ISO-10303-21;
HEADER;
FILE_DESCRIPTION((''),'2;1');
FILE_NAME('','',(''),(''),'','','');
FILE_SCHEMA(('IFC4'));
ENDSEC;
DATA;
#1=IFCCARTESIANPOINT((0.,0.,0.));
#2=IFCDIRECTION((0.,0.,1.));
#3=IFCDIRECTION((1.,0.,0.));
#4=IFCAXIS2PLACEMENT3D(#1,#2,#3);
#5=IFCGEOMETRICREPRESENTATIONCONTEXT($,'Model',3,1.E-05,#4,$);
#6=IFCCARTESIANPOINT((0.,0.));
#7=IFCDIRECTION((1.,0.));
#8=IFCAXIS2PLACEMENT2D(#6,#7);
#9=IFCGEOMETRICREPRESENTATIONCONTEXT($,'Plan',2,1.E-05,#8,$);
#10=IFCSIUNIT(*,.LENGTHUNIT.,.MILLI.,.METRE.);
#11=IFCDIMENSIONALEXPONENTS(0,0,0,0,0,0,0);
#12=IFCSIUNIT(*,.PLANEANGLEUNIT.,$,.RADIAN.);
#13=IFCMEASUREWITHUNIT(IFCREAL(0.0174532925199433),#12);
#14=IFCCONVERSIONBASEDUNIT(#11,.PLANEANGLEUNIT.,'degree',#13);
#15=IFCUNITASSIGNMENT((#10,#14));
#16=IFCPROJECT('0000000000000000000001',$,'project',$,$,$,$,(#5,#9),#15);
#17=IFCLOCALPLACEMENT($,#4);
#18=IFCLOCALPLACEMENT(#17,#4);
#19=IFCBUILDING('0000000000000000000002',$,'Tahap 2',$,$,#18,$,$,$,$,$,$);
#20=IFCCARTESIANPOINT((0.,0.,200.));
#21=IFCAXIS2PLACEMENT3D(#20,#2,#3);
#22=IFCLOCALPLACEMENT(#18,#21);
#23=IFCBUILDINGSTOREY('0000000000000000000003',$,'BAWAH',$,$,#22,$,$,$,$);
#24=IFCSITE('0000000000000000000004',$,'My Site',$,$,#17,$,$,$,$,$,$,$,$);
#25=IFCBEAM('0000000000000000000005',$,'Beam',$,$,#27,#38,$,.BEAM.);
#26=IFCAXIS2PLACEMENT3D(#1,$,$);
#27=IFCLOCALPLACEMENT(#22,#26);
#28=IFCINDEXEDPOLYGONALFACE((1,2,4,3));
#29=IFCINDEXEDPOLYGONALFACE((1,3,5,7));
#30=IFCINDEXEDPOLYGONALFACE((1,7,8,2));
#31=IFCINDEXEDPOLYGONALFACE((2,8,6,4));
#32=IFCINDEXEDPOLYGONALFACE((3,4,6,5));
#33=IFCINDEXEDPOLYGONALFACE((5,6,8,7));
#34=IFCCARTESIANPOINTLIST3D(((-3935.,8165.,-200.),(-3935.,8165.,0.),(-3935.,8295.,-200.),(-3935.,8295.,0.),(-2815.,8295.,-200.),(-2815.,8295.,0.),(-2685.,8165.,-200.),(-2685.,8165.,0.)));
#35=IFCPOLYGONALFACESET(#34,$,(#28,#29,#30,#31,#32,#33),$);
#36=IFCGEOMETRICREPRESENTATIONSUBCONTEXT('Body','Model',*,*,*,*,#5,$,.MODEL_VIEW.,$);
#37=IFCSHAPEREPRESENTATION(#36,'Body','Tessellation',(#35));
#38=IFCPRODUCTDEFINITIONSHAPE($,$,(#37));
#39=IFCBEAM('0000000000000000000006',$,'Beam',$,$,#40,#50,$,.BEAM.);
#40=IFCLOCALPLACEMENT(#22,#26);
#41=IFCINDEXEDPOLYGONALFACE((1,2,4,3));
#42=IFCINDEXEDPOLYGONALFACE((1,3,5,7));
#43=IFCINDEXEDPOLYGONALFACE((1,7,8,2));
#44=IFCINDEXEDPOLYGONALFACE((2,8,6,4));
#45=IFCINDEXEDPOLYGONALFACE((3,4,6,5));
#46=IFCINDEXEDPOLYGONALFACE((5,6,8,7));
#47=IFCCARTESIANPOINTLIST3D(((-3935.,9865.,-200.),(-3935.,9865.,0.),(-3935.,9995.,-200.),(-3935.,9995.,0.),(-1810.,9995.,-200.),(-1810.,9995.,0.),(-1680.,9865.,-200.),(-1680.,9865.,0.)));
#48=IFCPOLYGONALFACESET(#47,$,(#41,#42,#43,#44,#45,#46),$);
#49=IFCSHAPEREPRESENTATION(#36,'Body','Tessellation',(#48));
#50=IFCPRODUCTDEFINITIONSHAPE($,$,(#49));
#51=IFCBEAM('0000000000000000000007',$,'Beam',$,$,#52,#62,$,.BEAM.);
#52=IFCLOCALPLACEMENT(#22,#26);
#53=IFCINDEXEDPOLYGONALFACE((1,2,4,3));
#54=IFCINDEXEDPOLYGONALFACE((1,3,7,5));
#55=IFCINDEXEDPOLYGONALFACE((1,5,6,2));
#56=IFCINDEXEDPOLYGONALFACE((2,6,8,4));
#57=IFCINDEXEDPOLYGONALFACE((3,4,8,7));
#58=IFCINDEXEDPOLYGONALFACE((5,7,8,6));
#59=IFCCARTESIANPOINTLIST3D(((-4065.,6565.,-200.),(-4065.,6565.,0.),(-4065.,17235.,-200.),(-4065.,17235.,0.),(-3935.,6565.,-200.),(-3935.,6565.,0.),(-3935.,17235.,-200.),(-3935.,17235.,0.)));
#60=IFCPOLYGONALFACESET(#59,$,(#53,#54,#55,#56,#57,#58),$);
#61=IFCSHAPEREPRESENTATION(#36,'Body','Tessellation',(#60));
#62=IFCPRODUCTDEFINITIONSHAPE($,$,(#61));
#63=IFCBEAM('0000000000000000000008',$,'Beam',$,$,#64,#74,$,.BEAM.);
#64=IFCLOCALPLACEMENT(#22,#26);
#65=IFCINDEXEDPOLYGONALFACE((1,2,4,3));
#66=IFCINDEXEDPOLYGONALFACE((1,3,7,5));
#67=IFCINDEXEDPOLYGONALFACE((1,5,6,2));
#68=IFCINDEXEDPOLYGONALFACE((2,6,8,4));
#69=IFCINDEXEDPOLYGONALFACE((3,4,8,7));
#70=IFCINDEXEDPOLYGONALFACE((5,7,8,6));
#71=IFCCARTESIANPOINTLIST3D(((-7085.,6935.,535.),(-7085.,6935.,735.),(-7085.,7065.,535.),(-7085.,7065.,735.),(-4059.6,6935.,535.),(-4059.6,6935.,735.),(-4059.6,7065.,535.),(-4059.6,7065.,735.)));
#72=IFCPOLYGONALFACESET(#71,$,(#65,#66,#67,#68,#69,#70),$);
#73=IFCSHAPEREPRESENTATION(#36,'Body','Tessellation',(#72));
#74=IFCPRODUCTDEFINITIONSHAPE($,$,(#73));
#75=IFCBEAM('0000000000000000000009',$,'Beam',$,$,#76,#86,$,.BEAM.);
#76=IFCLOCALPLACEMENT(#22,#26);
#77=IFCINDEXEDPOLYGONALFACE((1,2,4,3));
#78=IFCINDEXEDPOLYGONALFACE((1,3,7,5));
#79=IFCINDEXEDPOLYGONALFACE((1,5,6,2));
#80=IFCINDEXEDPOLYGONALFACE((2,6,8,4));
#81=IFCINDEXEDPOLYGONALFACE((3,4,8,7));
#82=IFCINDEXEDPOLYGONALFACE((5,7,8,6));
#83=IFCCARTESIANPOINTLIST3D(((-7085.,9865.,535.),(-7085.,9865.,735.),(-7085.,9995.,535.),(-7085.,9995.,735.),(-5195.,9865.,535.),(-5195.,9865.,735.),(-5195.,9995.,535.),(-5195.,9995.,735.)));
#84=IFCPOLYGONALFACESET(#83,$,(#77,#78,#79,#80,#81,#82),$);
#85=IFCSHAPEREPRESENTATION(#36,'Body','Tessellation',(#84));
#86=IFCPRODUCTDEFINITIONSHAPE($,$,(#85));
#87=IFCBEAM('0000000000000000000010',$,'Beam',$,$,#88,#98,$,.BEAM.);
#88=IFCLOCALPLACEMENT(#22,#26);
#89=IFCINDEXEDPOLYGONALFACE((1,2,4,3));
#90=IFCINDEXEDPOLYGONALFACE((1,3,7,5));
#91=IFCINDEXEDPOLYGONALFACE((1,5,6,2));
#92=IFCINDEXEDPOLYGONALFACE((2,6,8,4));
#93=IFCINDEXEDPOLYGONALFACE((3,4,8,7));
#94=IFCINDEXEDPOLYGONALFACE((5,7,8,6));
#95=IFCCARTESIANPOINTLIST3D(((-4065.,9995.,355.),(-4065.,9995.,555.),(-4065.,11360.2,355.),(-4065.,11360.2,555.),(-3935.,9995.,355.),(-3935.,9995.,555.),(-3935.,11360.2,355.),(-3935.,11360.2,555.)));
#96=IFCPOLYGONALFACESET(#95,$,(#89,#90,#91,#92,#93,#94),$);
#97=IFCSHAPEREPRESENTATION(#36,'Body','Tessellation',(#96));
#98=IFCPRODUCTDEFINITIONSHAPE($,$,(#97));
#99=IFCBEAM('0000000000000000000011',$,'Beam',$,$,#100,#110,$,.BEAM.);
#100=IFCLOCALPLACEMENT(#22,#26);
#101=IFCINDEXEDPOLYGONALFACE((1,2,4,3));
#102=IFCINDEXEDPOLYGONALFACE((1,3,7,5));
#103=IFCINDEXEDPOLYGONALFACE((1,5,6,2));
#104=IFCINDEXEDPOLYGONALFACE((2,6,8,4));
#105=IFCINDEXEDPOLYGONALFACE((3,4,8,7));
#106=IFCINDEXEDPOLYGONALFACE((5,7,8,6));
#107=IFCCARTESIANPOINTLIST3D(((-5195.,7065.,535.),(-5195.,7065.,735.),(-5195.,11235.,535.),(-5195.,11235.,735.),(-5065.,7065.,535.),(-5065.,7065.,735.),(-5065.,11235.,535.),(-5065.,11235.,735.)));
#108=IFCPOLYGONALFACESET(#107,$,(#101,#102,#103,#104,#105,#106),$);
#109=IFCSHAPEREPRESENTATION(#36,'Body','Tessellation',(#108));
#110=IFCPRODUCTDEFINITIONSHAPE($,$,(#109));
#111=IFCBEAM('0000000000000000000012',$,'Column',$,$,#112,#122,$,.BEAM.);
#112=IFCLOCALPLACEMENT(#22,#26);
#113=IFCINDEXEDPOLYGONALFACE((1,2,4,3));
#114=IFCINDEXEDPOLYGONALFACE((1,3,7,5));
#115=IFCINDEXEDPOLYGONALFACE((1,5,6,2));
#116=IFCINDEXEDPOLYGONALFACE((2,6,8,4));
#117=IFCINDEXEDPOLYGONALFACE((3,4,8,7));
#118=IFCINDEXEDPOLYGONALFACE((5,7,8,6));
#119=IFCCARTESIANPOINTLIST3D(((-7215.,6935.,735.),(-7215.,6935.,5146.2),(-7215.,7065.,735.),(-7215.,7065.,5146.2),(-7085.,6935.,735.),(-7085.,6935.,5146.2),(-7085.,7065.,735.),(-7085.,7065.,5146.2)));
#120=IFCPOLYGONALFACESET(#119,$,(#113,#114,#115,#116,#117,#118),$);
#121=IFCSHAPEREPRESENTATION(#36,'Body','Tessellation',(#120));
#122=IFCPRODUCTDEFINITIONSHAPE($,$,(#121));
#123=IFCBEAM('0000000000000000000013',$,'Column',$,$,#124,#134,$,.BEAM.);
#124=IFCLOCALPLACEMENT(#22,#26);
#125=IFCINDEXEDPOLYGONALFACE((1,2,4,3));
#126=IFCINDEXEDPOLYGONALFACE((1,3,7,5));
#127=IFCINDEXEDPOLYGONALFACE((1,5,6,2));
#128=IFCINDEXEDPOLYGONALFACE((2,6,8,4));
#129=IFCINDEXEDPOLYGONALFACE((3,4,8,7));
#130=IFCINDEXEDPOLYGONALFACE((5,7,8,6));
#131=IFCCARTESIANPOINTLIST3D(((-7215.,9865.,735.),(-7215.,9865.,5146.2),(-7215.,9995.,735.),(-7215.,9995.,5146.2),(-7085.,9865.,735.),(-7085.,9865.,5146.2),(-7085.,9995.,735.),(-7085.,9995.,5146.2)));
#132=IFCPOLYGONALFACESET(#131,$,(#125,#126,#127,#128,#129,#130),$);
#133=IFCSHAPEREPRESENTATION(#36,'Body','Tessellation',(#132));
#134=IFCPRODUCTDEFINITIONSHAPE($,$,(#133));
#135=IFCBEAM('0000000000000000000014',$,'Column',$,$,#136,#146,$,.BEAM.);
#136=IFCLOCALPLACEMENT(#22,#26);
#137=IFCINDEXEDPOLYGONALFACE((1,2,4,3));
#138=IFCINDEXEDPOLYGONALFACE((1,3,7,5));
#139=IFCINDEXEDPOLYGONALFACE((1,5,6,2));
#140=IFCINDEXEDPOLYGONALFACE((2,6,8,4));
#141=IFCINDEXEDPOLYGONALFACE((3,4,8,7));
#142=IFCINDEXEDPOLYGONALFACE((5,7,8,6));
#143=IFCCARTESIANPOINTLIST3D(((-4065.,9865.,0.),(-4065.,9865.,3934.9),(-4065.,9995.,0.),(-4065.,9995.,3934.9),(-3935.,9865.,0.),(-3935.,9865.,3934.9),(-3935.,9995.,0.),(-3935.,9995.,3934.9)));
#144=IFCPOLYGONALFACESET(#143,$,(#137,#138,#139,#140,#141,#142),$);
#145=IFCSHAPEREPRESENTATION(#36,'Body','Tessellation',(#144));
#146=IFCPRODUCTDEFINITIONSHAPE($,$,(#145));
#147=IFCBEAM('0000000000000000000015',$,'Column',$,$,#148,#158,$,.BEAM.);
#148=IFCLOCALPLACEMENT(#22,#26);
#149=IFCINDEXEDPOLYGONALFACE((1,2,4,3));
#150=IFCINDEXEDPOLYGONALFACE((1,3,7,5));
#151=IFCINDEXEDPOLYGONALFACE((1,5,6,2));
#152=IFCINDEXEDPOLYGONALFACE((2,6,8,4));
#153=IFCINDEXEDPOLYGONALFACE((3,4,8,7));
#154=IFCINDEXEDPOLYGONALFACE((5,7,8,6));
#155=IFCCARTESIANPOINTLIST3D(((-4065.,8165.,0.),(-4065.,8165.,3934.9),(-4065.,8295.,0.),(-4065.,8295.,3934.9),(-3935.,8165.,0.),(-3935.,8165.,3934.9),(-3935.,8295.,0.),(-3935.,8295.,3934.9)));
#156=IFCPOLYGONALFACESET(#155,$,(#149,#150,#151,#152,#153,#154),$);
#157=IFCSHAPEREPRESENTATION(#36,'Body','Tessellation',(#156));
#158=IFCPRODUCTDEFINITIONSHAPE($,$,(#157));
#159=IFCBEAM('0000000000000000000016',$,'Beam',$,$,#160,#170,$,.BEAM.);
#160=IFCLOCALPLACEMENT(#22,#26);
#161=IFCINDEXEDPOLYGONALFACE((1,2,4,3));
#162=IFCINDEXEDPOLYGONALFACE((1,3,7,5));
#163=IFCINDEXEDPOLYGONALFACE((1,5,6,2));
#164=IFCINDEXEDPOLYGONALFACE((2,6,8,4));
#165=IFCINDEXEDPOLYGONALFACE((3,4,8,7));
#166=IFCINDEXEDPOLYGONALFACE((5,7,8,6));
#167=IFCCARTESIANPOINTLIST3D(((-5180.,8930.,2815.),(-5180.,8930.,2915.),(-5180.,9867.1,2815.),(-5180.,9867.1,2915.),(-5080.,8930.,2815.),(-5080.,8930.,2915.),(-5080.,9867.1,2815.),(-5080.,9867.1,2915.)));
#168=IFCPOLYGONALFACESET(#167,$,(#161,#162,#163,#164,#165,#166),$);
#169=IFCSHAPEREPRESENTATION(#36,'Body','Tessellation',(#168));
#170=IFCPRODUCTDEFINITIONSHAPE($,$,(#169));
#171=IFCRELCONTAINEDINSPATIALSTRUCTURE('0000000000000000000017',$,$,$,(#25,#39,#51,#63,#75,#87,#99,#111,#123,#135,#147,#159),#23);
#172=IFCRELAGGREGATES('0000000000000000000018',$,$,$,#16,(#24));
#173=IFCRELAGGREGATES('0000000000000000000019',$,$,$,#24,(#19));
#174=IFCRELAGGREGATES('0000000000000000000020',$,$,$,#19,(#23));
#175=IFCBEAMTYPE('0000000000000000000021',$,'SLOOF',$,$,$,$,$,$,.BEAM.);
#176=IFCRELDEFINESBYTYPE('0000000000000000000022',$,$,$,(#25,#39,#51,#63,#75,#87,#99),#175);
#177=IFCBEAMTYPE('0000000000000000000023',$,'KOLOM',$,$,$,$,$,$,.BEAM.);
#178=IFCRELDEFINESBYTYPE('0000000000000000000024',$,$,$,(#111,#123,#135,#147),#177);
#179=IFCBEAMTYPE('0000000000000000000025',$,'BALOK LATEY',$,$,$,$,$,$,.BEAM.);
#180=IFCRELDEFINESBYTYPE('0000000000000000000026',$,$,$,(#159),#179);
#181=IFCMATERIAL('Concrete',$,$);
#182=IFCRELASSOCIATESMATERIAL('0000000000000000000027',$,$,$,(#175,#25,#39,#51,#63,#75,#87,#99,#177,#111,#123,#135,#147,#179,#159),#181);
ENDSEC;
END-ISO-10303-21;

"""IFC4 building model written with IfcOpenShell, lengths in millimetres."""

from ifc_helpers import new_model, entity, si_unit, converted_unit, frame, origin_with_axes, origin_2d_with_axis, place, context, subcontext, project, spatial, indexed_curve, rectangle, outline, extrude, clip, halfspace, material, material_profile, profile_set, profile_usage, type_object, element, save


model = new_model("IFC4")

# Units and contexts
model_context = context("Model", 3, precision=1e-05, world=origin_with_axes())
plan_context = context("Plan", 2, precision=1e-05, world=origin_2d_with_axis())
body_context_1 = subcontext(model_context, "Body", "Model", "MODEL_VIEW")
ifc_project = project(units=[si_unit("LENGTHUNIT", "METRE", prefix="MILLI"), converted_unit("PLANEANGLEUNIT", "degree", entity("IfcReal", 0.0174532925199433), si_unit("PLANEANGLEUNIT", "RADIAN"), dimensions=[0, 0, 0, 0, 0, 0, 0])], contexts=[model_context, plan_context])

# Site, building, storey
site_placement = place(None, origin_with_axes())
site = spatial("IfcSite", under=ifc_project, at=site_placement, Name="My Site")
building_placement = place(site_placement, origin_with_axes())
building = spatial("IfcBuilding", under=site, at=building_placement, Name="Tahap 2")
storey_placement = place(building_placement, frame((0.0, 0.0, 200.0), z_axis=(0.0, 0.0, 1.0), x_axis=(1.0, 0.0, 0.0)))
storey = spatial("IfcBuildingStorey", under=building, at=storey_placement, Name="BAWAH")

# Beams
ifc_material_1 = material(Name="Concrete")
ifc_material_profile_1 = material_profile(ifc_material_1, outline(indexed_curve([(-65.0, 100.0), (65.0, 100.0), (65.0, -100.0), (-65.0, -100.0), (-65.0, 100.0)])))
ifc_profile_set_1 = profile_set([ifc_material_profile_1])
ifc_profile_usage_1 = profile_usage(ifc_profile_set_1, cardinal=2)
beam_type_1 = type_object("IfcBeamType", Name="SLOOF", PredefinedType="BEAM", material=ifc_profile_set_1)
beam_1_placement = place(storey_placement, frame((-3935.0, 8230.0, -200.0), z_axis=(1.0, 0.0, 0.0), x_axis=(0.0, 1.0, 0.0)))
element("IfcBeam", 1, at=beam_1_placement, inside=storey, type_object=beam_type_1, material=ifc_profile_usage_1, Name="Beam", PredefinedType="BEAM", context=body_context_1, shape_type="Clipping", body=[
    clip(extrude(outline(indexed_curve([(-65.0, 100.0), (65.0, 100.0), (65.0, -100.0), (-65.0, -100.0), (-65.0, 100.0)])), frame((0.0, 100.0, 0.0), z_axis=(0.0, 0.0, 1.0), x_axis=(1.0, 0.0, 0.0)), (0.0, 0.0, 1.0), 1250.0), halfspace(frame((-65.0, 0.0, 1250.0), z_axis=(0.707109, 0.0, 0.707104), x_axis=(0.0, -1.0, 0.0)), False)),
])
ifc_profile_usage_2 = profile_usage(ifc_profile_set_1, cardinal=2)
beam_2_placement = place(storey_placement, frame((-3935.0, 9930.0, -200.0), z_axis=(1.0, 0.000001, 0.0), x_axis=(-0.000001, 1.0, 0.0)))
element("IfcBeam", 2, at=beam_2_placement, inside=storey, type_object=beam_type_1, material=ifc_profile_usage_2, Name="Beam", PredefinedType="BEAM", context=body_context_1, shape_type="Clipping", body=[
    clip(extrude(outline(indexed_curve([(-65.0, 100.0), (65.0, 100.0), (65.0, -100.0), (-65.0, -100.0), (-65.0, 100.0)])), frame((0.0, 100.0, 0.0), z_axis=(0.0, 0.0, 1.0), x_axis=(1.0, 0.0, 0.0)), (0.0, 0.0, 1.0), 2255.0), halfspace(frame((-65.0, 0.0, 2255.0), z_axis=(0.707109, 0.0, 0.707104), x_axis=(0.0, -1.0, 0.0)), False)),
])
ifc_profile_usage_3 = profile_usage(ifc_profile_set_1, cardinal=3)
beam_3_placement = place(storey_placement, frame((-3935.0, 6565.0, -200.0), z_axis=(0.0, 1.0, 0.0), x_axis=(-1.0, 0.0, 0.0)))
element("IfcBeam", 3, at=beam_3_placement, inside=storey, type_object=beam_type_1, material=ifc_profile_usage_3, Name="Beam", PredefinedType="BEAM", context=body_context_1, shape_type="SweptSolid", body=[
    extrude(outline(indexed_curve([(-65.0, 100.0), (65.0, 100.0), (65.0, -100.0), (-65.0, -100.0), (-65.0, 100.0)])), frame((65.0, 100.0, 0.0), z_axis=(0.0, 0.0, 1.0), x_axis=(1.0, 0.0, 0.0)), (0.0, 0.0, 1.0), 10670.0),
])
ifc_profile_usage_4 = profile_usage(ifc_profile_set_1, cardinal=2)
beam_4_placement = place(storey_placement, frame((-7085.0, 7000.0, 535.0), z_axis=(1.0, 0.0, 0.0), x_axis=(0.0, 1.0, 0.0)))
element("IfcBeam", 4, at=beam_4_placement, inside=storey, type_object=beam_type_1, material=ifc_profile_usage_4, Name="Beam", PredefinedType="BEAM", context=body_context_1, shape_type="SweptSolid", body=[
    extrude(outline(indexed_curve([(-65.0, 100.0), (65.0, 100.0), (65.0, -100.0), (-65.0, -100.0), (-65.0, 100.0)])), frame((0.0, 100.0, 0.0), z_axis=(0.0, 0.0, 1.0), x_axis=(1.0, 0.0, 0.0)), (0.0, 0.0, 1.0), 3025.4),
])
ifc_profile_usage_5 = profile_usage(ifc_profile_set_1, cardinal=2)
beam_5_placement = place(storey_placement, frame((-7085.0, 9930.0, 535.0), z_axis=(1.0, 0.0, 0.0), x_axis=(0.0, 1.0, 0.0)))
element("IfcBeam", 5, at=beam_5_placement, inside=storey, type_object=beam_type_1, material=ifc_profile_usage_5, Name="Beam", PredefinedType="BEAM", context=body_context_1, shape_type="SweptSolid", body=[
    extrude(outline(indexed_curve([(-65.0, 100.0), (65.0, 100.0), (65.0, -100.0), (-65.0, -100.0), (-65.0, 100.0)])), frame((0.0, 100.0, 0.0), z_axis=(0.0, 0.0, 1.0), x_axis=(1.0, 0.0, 0.0)), (0.0, 0.0, 1.0), 1890.0),
])
ifc_profile_usage_6 = profile_usage(ifc_profile_set_1, cardinal=3)
beam_6_placement = place(storey_placement, frame((-3935.0, 9995.0, 355.0), z_axis=(0.0, 1.0, 0.0), x_axis=(-1.0, 0.0, 0.0)))
element("IfcBeam", 6, at=beam_6_placement, inside=storey, type_object=beam_type_1, material=ifc_profile_usage_6, Name="Beam", PredefinedType="BEAM", context=body_context_1, shape_type="SweptSolid", body=[
    extrude(outline(indexed_curve([(-65.0, 100.0), (65.0, 100.0), (65.0, -100.0), (-65.0, -100.0), (-65.0, 100.0)])), frame((65.0, 100.0, 0.0), z_axis=(0.0, 0.0, 1.0), x_axis=(1.0, 0.0, 0.0)), (0.0, 0.0, 1.0), 1365.2),
])
ifc_profile_usage_7 = profile_usage(ifc_profile_set_1, cardinal=3)
beam_7_placement = place(storey_placement, frame((-5065.0, 7065.0, 535.0), z_axis=(0.0, 1.0, 0.0), x_axis=(-1.0, 0.0, 0.0)))
element("IfcBeam", 7, at=beam_7_placement, inside=storey, type_object=beam_type_1, material=ifc_profile_usage_7, Name="Beam", PredefinedType="BEAM", context=body_context_1, shape_type="SweptSolid", body=[
    extrude(outline(indexed_curve([(-65.0, 100.0), (65.0, 100.0), (65.0, -100.0), (-65.0, -100.0), (-65.0, 100.0)])), frame((65.0, 100.0, 0.0), z_axis=(0.0, 0.0, 1.0), x_axis=(1.0, 0.0, 0.0)), (0.0, 0.0, 1.0), 4170.0),
])
ifc_material_profile_2 = material_profile(ifc_material_1, rectangle(XDim=130.0, YDim=130.0, kind="CURVE"))
ifc_profile_set_2 = profile_set([ifc_material_profile_2])
ifc_profile_usage_8 = profile_usage(ifc_profile_set_2, cardinal=5)
beam_type_2 = type_object("IfcBeamType", Name="KOLOM", PredefinedType="BEAM", material=ifc_profile_set_2)
beam_8_placement = place(storey_placement, frame((-7150.0, 7000.0, 735.0), z_axis=(0.0, 0.0, 1.0), x_axis=(1.0, 0.0, 0.0)))
element("IfcBeam", 8, at=beam_8_placement, inside=storey, type_object=beam_type_2, material=ifc_profile_usage_8, Name="Column", PredefinedType="BEAM", context=body_context_1, shape_type="SweptSolid", body=[
    extrude(rectangle(XDim=130.0, YDim=130.0, kind="CURVE"), origin_with_axes(), (0.0, 0.0, 1.0), 4411.2),
])
ifc_profile_usage_9 = profile_usage(ifc_profile_set_2, cardinal=5)
beam_9_placement = place(storey_placement, frame((-7150.0, 9930.0, 735.0), z_axis=(0.0, 0.0, 1.0), x_axis=(1.0, 0.0, 0.0)))
element("IfcBeam", 9, at=beam_9_placement, inside=storey, type_object=beam_type_2, material=ifc_profile_usage_9, Name="Column", PredefinedType="BEAM", context=body_context_1, shape_type="SweptSolid", body=[
    extrude(rectangle(XDim=130.0, YDim=130.0, kind="CURVE"), origin_with_axes(), (0.0, 0.0, 1.0), 4411.2),
])
ifc_profile_usage_10 = profile_usage(ifc_profile_set_2, cardinal=5)
beam_10_placement = place(storey_placement, frame((-4000.0, 9930.0, 0.0), z_axis=(0.0, 0.0, 1.0), x_axis=(1.0, 0.0, 0.0)))
element("IfcBeam", 10, at=beam_10_placement, inside=storey, type_object=beam_type_2, material=ifc_profile_usage_10, Name="Column", PredefinedType="BEAM", context=body_context_1, shape_type="SweptSolid", body=[
    extrude(rectangle(XDim=130.0, YDim=130.0, kind="CURVE"), origin_with_axes(), (0.0, 0.0, 1.0), 3934.9),
])
ifc_profile_usage_11 = profile_usage(ifc_profile_set_2, cardinal=5)
beam_11_placement = place(storey_placement, frame((-4000.0, 8230.0, 0.0), z_axis=(0.0, 0.0, 1.0), x_axis=(1.0, 0.0, 0.0)))
element("IfcBeam", 11, at=beam_11_placement, inside=storey, type_object=beam_type_2, material=ifc_profile_usage_11, Name="Column", PredefinedType="BEAM", context=body_context_1, shape_type="SweptSolid", body=[
    extrude(rectangle(XDim=130.0, YDim=130.0, kind="CURVE"), origin_with_axes(), (0.0, 0.0, 1.0), 3934.9),
])

# Beam
ifc_material_profile_3 = material_profile(ifc_material_1, rectangle(XDim=100.0, YDim=100.0))
ifc_profile_set_3 = profile_set([ifc_material_profile_3])
ifc_profile_usage_12 = profile_usage(ifc_profile_set_3, cardinal=2)
beam_type_3 = type_object("IfcBeamType", Name="BALOK LATEY", PredefinedType="BEAM", material=ifc_profile_set_3)
beam_12_placement = place(storey_placement, frame((-5130.0, 8930.0, 2815.0), z_axis=(0.0, 1.0, 0.0), x_axis=(-1.0, 0.0, 0.0)))
element("IfcBeam", 12, at=beam_12_placement, inside=storey, type_object=beam_type_3, material=ifc_profile_usage_12, Name="Beam", PredefinedType="BEAM", context=body_context_1, shape_type="SweptSolid", body=[
    extrude(rectangle(XDim=100.0, YDim=100.0), frame((0.0, 50.0, 0.0), z_axis=(0.0, 0.0, 1.0), x_axis=(1.0, 0.0, 0.0)), (0.0, 0.0, 1.0), 937.2),
])

save(model, "model.ifc")
